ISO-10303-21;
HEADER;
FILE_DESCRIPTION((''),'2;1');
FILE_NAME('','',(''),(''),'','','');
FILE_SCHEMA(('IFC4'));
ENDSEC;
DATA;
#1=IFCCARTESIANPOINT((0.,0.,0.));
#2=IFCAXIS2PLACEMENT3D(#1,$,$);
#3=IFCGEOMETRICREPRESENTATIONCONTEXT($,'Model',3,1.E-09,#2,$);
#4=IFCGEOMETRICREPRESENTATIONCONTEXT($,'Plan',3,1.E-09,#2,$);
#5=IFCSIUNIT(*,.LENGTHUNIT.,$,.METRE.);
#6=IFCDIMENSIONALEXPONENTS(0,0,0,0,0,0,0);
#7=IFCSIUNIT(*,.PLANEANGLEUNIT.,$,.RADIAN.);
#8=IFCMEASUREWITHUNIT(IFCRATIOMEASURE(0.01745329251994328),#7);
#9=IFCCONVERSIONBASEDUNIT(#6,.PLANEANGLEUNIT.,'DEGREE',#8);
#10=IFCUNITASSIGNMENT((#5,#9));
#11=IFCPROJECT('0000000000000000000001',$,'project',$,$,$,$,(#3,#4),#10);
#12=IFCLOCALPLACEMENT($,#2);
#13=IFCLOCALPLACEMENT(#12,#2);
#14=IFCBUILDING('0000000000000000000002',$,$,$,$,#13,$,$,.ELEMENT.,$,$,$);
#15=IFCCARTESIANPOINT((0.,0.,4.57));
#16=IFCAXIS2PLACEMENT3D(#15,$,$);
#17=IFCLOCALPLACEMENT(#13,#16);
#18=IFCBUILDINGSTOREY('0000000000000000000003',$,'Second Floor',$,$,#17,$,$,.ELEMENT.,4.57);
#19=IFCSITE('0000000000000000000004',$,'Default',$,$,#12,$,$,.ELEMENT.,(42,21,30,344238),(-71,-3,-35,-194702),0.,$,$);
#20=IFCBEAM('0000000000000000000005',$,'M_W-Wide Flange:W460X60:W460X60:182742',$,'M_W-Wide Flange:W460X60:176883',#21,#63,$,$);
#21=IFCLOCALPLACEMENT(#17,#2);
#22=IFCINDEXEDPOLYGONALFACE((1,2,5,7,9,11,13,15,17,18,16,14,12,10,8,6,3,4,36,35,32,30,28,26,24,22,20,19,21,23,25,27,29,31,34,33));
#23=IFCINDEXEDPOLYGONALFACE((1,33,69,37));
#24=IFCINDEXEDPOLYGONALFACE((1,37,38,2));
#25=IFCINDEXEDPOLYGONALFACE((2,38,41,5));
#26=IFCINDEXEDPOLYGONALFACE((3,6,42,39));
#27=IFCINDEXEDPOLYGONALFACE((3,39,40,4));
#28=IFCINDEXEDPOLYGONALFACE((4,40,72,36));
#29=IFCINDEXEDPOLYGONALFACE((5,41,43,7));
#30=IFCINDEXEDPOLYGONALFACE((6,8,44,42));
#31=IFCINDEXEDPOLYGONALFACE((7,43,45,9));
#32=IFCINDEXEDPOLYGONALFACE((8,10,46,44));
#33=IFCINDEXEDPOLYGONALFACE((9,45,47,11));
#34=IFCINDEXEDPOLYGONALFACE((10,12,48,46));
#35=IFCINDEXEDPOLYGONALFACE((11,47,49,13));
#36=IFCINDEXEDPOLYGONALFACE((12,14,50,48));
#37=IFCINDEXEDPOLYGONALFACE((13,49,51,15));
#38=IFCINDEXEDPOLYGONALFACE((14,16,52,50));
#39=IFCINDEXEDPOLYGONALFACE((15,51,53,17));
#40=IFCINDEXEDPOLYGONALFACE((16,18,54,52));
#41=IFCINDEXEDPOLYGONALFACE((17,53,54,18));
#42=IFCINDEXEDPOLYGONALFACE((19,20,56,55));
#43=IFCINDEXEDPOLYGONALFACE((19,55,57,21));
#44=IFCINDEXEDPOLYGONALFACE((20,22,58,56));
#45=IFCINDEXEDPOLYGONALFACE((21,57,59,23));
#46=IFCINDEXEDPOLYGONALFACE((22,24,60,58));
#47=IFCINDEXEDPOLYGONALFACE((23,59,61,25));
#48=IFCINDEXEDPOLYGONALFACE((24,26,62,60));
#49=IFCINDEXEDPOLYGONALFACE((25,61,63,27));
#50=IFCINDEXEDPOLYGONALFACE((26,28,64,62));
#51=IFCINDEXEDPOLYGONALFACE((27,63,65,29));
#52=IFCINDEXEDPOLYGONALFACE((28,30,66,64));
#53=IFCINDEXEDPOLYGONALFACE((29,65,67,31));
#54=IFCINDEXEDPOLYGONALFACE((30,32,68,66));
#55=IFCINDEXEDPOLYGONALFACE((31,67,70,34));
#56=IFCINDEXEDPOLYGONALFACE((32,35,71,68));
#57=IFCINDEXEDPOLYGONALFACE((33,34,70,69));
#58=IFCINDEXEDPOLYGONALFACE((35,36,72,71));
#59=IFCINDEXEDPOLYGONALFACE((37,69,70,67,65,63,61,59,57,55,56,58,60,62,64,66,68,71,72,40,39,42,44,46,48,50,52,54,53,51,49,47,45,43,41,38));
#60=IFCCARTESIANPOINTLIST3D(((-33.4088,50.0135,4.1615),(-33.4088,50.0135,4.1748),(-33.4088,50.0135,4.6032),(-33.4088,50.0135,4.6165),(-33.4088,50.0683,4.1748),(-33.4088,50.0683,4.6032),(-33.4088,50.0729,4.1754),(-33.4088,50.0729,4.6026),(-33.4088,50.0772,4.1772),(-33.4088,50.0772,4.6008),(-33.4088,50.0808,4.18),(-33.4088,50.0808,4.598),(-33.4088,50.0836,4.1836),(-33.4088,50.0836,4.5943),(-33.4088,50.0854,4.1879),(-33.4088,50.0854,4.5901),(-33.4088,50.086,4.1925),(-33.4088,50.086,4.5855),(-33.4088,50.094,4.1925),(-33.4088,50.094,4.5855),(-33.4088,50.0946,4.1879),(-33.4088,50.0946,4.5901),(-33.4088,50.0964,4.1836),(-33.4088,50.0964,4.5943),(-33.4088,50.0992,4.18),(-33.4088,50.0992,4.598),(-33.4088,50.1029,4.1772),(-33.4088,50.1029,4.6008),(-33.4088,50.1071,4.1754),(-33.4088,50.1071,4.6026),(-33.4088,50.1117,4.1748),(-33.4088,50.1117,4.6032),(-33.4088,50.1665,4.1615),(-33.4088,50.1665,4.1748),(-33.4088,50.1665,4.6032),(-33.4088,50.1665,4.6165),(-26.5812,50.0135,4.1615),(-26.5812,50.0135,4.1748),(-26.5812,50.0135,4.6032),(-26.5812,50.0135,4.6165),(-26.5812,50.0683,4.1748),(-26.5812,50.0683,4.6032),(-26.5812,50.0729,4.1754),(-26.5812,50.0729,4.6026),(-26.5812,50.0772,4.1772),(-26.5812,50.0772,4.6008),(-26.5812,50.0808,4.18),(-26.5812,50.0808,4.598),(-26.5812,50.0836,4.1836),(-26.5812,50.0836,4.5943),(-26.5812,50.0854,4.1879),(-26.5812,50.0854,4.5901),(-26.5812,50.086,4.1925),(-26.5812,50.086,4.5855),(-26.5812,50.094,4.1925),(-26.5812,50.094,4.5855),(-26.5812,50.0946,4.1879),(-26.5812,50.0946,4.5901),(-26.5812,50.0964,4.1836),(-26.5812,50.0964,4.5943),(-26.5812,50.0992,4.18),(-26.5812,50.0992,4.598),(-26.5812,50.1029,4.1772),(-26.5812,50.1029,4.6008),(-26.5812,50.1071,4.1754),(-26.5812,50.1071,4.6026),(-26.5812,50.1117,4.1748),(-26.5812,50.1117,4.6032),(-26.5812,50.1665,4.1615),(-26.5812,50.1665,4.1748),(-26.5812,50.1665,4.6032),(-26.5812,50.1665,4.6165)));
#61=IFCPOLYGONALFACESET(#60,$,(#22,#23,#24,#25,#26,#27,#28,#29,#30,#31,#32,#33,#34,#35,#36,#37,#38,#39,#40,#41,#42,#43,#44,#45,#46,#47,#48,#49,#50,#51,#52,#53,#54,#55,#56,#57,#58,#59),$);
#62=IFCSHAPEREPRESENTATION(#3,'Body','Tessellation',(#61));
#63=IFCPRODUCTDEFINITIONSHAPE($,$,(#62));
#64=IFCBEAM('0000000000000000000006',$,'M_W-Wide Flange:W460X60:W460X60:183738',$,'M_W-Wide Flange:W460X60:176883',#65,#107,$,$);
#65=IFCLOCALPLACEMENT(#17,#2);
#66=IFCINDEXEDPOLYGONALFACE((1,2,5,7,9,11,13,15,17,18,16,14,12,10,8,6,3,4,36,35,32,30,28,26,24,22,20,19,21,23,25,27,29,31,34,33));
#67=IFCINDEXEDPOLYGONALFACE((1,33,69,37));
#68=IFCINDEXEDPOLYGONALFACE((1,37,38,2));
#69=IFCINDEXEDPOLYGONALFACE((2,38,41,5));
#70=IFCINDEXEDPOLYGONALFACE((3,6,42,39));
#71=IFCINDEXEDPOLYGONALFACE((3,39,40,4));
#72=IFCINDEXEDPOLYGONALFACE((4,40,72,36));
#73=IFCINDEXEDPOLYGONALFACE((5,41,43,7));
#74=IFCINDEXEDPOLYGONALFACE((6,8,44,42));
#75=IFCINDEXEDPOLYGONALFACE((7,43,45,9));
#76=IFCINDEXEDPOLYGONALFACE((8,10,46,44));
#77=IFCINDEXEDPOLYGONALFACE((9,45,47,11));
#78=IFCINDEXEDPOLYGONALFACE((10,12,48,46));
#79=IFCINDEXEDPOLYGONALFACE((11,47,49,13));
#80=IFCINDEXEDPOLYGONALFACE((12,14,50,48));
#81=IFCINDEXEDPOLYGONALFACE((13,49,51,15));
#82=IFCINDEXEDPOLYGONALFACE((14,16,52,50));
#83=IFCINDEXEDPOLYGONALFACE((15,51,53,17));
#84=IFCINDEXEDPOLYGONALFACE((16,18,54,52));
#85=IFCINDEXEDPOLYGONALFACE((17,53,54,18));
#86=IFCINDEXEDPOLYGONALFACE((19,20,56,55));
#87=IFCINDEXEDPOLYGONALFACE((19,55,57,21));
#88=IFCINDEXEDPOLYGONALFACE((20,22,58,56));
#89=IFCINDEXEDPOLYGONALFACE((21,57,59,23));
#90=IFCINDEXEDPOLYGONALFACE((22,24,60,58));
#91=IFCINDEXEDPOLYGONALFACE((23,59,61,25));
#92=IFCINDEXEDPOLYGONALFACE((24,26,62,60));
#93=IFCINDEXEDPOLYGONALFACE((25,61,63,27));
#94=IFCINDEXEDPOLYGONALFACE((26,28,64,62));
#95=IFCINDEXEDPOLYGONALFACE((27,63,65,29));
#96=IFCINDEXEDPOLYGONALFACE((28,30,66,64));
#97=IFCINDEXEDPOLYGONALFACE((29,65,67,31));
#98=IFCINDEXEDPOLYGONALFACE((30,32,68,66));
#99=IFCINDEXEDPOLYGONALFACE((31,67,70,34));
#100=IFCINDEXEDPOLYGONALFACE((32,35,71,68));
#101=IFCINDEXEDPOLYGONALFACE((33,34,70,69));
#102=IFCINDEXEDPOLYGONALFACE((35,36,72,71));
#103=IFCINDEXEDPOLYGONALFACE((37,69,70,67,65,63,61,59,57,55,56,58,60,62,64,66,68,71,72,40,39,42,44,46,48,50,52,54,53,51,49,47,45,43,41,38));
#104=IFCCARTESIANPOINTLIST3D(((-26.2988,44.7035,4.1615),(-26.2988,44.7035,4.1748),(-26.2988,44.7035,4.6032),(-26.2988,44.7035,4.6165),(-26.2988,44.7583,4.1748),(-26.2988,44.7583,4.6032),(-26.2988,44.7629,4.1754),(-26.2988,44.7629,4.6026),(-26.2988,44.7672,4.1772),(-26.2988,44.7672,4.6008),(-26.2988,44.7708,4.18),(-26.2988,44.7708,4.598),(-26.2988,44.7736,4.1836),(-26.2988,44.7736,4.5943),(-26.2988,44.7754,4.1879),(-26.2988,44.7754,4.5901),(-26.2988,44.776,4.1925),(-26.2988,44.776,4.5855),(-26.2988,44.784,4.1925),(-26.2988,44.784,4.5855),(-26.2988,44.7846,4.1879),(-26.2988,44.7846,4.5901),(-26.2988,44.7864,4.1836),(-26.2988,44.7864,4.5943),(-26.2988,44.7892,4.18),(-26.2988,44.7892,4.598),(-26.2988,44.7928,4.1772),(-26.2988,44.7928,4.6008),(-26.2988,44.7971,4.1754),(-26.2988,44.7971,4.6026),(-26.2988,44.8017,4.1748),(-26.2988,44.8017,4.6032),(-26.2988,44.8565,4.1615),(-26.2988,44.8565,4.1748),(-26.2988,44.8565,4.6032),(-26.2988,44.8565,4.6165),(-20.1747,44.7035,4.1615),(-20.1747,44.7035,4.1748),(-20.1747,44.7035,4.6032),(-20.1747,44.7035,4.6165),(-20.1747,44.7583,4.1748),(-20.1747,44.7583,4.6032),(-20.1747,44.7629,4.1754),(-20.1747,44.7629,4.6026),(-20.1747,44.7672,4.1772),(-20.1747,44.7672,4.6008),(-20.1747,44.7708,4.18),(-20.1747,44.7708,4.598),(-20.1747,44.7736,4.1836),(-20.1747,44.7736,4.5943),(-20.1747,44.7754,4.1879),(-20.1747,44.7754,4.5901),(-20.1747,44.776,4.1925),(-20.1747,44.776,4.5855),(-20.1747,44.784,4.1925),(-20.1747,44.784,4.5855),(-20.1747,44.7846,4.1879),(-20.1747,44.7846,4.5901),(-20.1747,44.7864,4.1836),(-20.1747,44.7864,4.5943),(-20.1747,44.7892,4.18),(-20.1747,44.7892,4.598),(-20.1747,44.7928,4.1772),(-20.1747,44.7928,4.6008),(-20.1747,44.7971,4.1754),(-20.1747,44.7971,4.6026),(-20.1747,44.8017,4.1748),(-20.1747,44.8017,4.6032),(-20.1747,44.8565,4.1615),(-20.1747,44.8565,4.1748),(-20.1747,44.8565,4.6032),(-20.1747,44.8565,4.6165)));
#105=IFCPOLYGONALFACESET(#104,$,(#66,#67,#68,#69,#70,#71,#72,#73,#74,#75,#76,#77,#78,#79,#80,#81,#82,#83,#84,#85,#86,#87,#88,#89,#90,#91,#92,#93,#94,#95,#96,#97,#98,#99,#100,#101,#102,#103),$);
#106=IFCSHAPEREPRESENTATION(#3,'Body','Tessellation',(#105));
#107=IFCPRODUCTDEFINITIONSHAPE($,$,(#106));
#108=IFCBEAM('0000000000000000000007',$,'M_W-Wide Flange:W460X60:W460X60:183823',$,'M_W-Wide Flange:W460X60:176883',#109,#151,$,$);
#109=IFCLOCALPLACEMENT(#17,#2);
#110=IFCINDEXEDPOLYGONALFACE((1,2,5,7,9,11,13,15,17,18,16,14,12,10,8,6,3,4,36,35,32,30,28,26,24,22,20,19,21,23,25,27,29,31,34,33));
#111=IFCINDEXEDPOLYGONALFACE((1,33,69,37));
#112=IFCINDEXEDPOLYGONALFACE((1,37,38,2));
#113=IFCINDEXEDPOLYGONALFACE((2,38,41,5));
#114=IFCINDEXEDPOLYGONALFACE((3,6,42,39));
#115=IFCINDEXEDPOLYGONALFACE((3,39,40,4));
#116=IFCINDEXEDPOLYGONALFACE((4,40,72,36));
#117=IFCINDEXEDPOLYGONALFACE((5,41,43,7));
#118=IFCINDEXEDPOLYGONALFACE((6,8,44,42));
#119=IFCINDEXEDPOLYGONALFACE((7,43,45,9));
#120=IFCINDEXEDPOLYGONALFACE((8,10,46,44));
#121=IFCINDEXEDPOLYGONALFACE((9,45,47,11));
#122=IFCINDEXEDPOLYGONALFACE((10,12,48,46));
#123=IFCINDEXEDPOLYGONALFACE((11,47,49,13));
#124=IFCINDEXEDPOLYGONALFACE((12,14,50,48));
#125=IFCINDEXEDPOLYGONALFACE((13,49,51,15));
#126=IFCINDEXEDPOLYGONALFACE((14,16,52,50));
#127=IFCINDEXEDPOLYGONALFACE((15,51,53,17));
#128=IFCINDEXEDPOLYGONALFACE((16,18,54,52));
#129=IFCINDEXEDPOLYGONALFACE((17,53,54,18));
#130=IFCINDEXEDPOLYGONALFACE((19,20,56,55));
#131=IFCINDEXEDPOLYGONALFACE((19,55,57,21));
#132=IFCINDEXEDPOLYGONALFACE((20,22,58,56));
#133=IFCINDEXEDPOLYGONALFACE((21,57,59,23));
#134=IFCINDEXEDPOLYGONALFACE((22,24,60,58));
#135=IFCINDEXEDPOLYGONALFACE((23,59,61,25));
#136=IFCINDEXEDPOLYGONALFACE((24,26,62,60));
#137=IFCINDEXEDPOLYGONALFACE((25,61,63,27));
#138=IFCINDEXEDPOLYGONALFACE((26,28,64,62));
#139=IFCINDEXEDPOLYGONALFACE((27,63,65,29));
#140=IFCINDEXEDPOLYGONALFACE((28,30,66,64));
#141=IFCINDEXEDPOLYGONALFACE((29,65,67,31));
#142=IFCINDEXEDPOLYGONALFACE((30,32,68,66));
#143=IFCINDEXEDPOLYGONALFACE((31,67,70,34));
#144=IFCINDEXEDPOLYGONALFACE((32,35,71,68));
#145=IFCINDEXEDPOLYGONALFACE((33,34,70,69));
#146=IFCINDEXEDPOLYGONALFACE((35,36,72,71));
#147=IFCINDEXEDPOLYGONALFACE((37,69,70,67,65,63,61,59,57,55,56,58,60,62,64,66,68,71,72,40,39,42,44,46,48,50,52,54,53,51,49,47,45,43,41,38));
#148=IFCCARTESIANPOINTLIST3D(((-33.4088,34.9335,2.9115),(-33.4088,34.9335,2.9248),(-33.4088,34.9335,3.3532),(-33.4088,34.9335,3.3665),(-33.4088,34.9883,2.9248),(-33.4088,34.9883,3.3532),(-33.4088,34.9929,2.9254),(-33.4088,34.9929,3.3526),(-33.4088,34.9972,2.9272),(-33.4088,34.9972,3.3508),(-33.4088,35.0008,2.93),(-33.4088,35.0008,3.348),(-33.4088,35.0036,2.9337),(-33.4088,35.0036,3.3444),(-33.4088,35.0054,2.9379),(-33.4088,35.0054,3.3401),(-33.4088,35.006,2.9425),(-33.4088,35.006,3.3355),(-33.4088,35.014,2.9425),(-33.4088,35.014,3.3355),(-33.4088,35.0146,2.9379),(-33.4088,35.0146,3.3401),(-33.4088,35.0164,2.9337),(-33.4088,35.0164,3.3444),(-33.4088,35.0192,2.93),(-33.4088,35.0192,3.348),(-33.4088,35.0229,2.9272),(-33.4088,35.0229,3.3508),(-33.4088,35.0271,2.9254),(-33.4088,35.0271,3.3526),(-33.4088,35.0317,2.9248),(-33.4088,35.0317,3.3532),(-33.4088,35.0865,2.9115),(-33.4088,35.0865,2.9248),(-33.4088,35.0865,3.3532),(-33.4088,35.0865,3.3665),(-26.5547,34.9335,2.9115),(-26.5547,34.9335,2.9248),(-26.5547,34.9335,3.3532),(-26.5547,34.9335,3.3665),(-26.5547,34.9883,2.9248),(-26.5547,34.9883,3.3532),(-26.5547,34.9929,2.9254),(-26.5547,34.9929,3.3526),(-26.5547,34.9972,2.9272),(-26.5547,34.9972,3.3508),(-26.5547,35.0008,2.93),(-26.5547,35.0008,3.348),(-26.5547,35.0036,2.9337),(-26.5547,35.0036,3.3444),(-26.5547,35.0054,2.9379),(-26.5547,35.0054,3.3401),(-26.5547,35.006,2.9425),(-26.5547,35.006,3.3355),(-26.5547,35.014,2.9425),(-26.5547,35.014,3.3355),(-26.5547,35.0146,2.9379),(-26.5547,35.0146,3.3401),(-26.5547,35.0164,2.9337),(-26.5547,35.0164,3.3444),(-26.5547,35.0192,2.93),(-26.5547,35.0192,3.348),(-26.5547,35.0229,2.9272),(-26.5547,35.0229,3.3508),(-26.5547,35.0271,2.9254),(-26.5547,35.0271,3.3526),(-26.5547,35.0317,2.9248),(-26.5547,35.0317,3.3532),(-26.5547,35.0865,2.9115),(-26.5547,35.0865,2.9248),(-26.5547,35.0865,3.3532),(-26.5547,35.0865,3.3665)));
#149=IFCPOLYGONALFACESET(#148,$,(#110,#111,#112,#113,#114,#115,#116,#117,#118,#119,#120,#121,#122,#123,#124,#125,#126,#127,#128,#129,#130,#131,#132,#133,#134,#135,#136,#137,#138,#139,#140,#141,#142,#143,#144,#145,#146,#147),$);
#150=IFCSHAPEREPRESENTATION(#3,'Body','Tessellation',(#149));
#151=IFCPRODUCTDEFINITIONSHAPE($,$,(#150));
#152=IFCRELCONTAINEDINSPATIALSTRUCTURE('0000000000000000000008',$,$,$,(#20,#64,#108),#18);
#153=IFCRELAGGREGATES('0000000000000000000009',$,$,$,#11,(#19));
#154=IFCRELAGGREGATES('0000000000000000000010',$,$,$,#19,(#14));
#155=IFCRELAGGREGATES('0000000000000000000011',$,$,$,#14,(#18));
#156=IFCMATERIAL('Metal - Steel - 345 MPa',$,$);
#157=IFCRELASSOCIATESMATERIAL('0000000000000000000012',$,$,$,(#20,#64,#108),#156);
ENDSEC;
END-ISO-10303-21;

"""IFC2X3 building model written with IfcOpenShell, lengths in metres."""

from ifc_helpers import new_model, entity, si_unit, converted_unit, frame, frame_2d, origin, place, context, project, spatial, polyline, circle_curve, parameter, trimmed, segment, composite_curve, outline, extrude, material, element, save


model = new_model("IFC2X3")

# Units and contexts
model_context = context("Model", 3, precision=1e-09, world=origin())
plan_context = context("Plan", 3, precision=1e-09, world=origin())
ifc_project = project(units=[si_unit("LENGTHUNIT", "METRE"), converted_unit("PLANEANGLEUNIT", "DEGREE", entity("IfcRatioMeasure", 0.01745329251994328), si_unit("PLANEANGLEUNIT", "RADIAN"), dimensions=[0, 0, 0, 0, 0, 0, 0])], contexts=[model_context, plan_context])

# Site, building, storey
site_placement = place(None, origin())
site = spatial("IfcSite", under=ifc_project, at=site_placement, Name="Default", CompositionType="ELEMENT", RefLatitude=(42, 21, 30, 344238), RefLongitude=(-71, -3, -35, -194702), RefElevation=0.0)
building_placement = place(site_placement, origin())
building = spatial("IfcBuilding", under=site, at=building_placement, CompositionType="ELEMENT")
storey_placement = place(building_placement, frame((0.0, 0.0, 4.57)))
storey = spatial("IfcBuildingStorey", under=building, at=storey_placement, Name="Second Floor", CompositionType="ELEMENT", Elevation=4.57)

# Shared definitions
ifc_material = material(Name="Metal - Steel - 345 MPa")

# Beams
beam_1_placement = place(storey_placement, frame((-33.5473, 50.09, 4.6165), z_axis=(0.0, 0.0, 1.0), x_axis=(0.0, -1.0, 0.0)))
element("IfcBeam", 1, at=beam_1_placement, inside=storey, material=ifc_material, Name="M_W-Wide Flange:W460X60:W460X60:182742", ObjectType="M_W-Wide Flange:W460X60:176883", context=model_context, shape_type="SweptSolid", body=[
    extrude(outline(composite_curve([segment(polyline([(-0.0765, -0.2142), (-0.0765, -0.2275)]), True, "CONTINUOUS"), segment(polyline([(-0.0765, -0.2275), (0.0765, -0.2275)]), True, "CONTINUOUS"), segment(polyline([(0.0765, -0.2275), (0.0765, -0.2142)]), True, "CONTINUOUS"), segment(polyline([(0.0765, -0.2142), (0.0217, -0.2142)]), True, "CONTINUOUS"), segment(trimmed(circle_curve(frame_2d((0.0217, -0.1965), x_axis=(0.0, -1.0)), 0.0177), [parameter(270.0)], [parameter(360.0)], True, "PARAMETER"), False, "CONTINUOUS"), segment(polyline([(0.004, -0.1965), (0.004, 0.1965)]), True, "CONTINUOUS"), segment(trimmed(circle_curve(frame_2d((0.0217, 0.1965), x_axis=(-1.0, 0.0)), 0.0177), [parameter(270.0)], [parameter(360.0)], True, "PARAMETER"), False, "CONTINUOUS"), segment(polyline([(0.0217, 0.2142), (0.0765, 0.2142)]), True, "CONTINUOUS"), segment(polyline([(0.0765, 0.2142), (0.0765, 0.2275)]), True, "CONTINUOUS"), segment(polyline([(0.0765, 0.2275), (-0.0765, 0.2275)]), True, "CONTINUOUS"), segment(polyline([(-0.0765, 0.2275), (-0.0765, 0.2142)]), True, "CONTINUOUS"), segment(polyline([(-0.0765, 0.2142), (-0.0217, 0.2142)]), True, "CONTINUOUS"), segment(trimmed(circle_curve(frame_2d((-0.0217, 0.1965), x_axis=(0.0, 1.0)), 0.0177), [parameter(270.0)], [parameter(360.0)], True, "PARAMETER"), False, "CONTINUOUS"), segment(polyline([(-0.004, 0.1965), (-0.004, -0.1965)]), True, "CONTINUOUS"), segment(trimmed(circle_curve(frame_2d((-0.0217, -0.1965), x_axis=(1.0, 0.0)), 0.0177), [parameter(270.0)], [parameter(0.0)], True, "PARAMETER"), False, "CONTINUOUS"), segment(polyline([(-0.0217, -0.2142), (-0.0765, -0.2142)]), True, "CONTINUOUS")], self_intersect=False)), frame((0.0, 0.1385, -0.2275), z_axis=(0.0, -1.0, 0.0), x_axis=(1.0, 0.0, 0.0)), (0.0, 0.0, -1.0), 6.8276),
])
beam_2_placement = place(storey_placement, frame((-26.437, 44.78, 4.6165), z_axis=(0.0, 0.0, 1.0), x_axis=(0.0, -1.0, 0.0)))
element("IfcBeam", 2, at=beam_2_placement, inside=storey, material=ifc_material, Name="M_W-Wide Flange:W460X60:W460X60:183738", ObjectType="M_W-Wide Flange:W460X60:176883", context=model_context, shape_type="SweptSolid", body=[
    extrude(outline(composite_curve([segment(polyline([(-0.0765, -0.2142), (-0.0765, -0.2275)]), True, "CONTINUOUS"), segment(polyline([(-0.0765, -0.2275), (0.0765, -0.2275)]), True, "CONTINUOUS"), segment(polyline([(0.0765, -0.2275), (0.0765, -0.2142)]), True, "CONTINUOUS"), segment(polyline([(0.0765, -0.2142), (0.0217, -0.2142)]), True, "CONTINUOUS"), segment(trimmed(circle_curve(frame_2d((0.0217, -0.1965), x_axis=(0.0, -1.0)), 0.0177), [parameter(270.0)], [parameter(360.0)], True, "PARAMETER"), False, "CONTINUOUS"), segment(polyline([(0.004, -0.1965), (0.004, 0.1965)]), True, "CONTINUOUS"), segment(trimmed(circle_curve(frame_2d((0.0217, 0.1965), x_axis=(-1.0, 0.0)), 0.0177), [parameter(270.0)], [parameter(360.0)], True, "PARAMETER"), False, "CONTINUOUS"), segment(polyline([(0.0217, 0.2142), (0.0765, 0.2142)]), True, "CONTINUOUS"), segment(polyline([(0.0765, 0.2142), (0.0765, 0.2275)]), True, "CONTINUOUS"), segment(polyline([(0.0765, 0.2275), (-0.0765, 0.2275)]), True, "CONTINUOUS"), segment(polyline([(-0.0765, 0.2275), (-0.0765, 0.2142)]), True, "CONTINUOUS"), segment(polyline([(-0.0765, 0.2142), (-0.0217, 0.2142)]), True, "CONTINUOUS"), segment(trimmed(circle_curve(frame_2d((-0.0217, 0.1965), x_axis=(0.0, 1.0)), 0.0177), [parameter(270.0)], [parameter(360.0)], True, "PARAMETER"), False, "CONTINUOUS"), segment(polyline([(-0.004, 0.1965), (-0.004, -0.1965)]), True, "CONTINUOUS"), segment(trimmed(circle_curve(frame_2d((-0.0217, -0.1965), x_axis=(1.0, 0.0)), 0.0177), [parameter(270.0)], [parameter(0.0)], True, "PARAMETER"), False, "CONTINUOUS"), segment(polyline([(-0.0217, -0.2142), (-0.0765, -0.2142)]), True, "CONTINUOUS")], self_intersect=False)), frame((0.0, 0.1382, -0.2275), z_axis=(0.0, -1.0, 0.0), x_axis=(1.0, 0.0, 0.0)), (0.0, 0.0, -1.0), 6.1241),
])
beam_3_placement = place(storey_placement, frame((-26.5517, 35.01, 3.3665), z_axis=(0.0, 0.0, 1.0), x_axis=(0.0, 1.0, 0.0)))
element("IfcBeam", 3, at=beam_3_placement, inside=storey, material=ifc_material, Name="M_W-Wide Flange:W460X60:W460X60:183823", ObjectType="M_W-Wide Flange:W460X60:176883", context=model_context, shape_type="SweptSolid", body=[
    extrude(outline(composite_curve([segment(polyline([(0.2142, -0.0765), (0.2275, -0.0765)]), True, "CONTINUOUS"), segment(polyline([(0.2275, -0.0765), (0.2275, 0.0765)]), True, "CONTINUOUS"), segment(polyline([(0.2275, 0.0765), (0.2142, 0.0765)]), True, "CONTINUOUS"), segment(polyline([(0.2142, 0.0765), (0.2142, 0.0217)]), True, "CONTINUOUS"), segment(trimmed(circle_curve(frame_2d((0.1965, 0.0217), x_axis=(1.0, 0.0)), 0.0177), [parameter(270.0)], [parameter(360.0)], True, "PARAMETER"), False, "CONTINUOUS"), segment(polyline([(0.1965, 0.004), (-0.1965, 0.004)]), True, "CONTINUOUS"), segment(trimmed(circle_curve(frame_2d((-0.1965, 0.0217), x_axis=(0.0, -1.0)), 0.0177), [parameter(270.0)], [parameter(360.0)], True, "PARAMETER"), False, "CONTINUOUS"), segment(polyline([(-0.2142, 0.0217), (-0.2142, 0.0765)]), True, "CONTINUOUS"), segment(polyline([(-0.2142, 0.0765), (-0.2275, 0.0765)]), True, "CONTINUOUS"), segment(polyline([(-0.2275, 0.0765), (-0.2275, -0.0765)]), True, "CONTINUOUS"), segment(polyline([(-0.2275, -0.0765), (-0.2142, -0.0765)]), True, "CONTINUOUS"), segment(polyline([(-0.2142, -0.0765), (-0.2142, -0.0217)]), True, "CONTINUOUS"), segment(trimmed(circle_curve(frame_2d((-0.1965, -0.0217), x_axis=(-1.0, 0.0)), 0.0177), [parameter(270.0)], [parameter(360.0)], True, "PARAMETER"), False, "CONTINUOUS"), segment(polyline([(-0.1965, -0.004), (0.1965, -0.004)]), True, "CONTINUOUS"), segment(trimmed(circle_curve(frame_2d((0.1965, -0.0217), x_axis=(0.0, 1.0)), 0.0177), [parameter(270.0)], [parameter(0.0)], True, "PARAMETER"), False, "CONTINUOUS"), segment(polyline([(0.2142, -0.0217), (0.2142, -0.0765)]), True, "CONTINUOUS")], self_intersect=False)), frame((0.0, 6.8571, -0.2275), z_axis=(0.0, -1.0, 0.0), x_axis=(0.0, 0.0, -1.0)), (0.0, 0.0, 1.0), 6.8541),
])

save(model, "model.ifc")
